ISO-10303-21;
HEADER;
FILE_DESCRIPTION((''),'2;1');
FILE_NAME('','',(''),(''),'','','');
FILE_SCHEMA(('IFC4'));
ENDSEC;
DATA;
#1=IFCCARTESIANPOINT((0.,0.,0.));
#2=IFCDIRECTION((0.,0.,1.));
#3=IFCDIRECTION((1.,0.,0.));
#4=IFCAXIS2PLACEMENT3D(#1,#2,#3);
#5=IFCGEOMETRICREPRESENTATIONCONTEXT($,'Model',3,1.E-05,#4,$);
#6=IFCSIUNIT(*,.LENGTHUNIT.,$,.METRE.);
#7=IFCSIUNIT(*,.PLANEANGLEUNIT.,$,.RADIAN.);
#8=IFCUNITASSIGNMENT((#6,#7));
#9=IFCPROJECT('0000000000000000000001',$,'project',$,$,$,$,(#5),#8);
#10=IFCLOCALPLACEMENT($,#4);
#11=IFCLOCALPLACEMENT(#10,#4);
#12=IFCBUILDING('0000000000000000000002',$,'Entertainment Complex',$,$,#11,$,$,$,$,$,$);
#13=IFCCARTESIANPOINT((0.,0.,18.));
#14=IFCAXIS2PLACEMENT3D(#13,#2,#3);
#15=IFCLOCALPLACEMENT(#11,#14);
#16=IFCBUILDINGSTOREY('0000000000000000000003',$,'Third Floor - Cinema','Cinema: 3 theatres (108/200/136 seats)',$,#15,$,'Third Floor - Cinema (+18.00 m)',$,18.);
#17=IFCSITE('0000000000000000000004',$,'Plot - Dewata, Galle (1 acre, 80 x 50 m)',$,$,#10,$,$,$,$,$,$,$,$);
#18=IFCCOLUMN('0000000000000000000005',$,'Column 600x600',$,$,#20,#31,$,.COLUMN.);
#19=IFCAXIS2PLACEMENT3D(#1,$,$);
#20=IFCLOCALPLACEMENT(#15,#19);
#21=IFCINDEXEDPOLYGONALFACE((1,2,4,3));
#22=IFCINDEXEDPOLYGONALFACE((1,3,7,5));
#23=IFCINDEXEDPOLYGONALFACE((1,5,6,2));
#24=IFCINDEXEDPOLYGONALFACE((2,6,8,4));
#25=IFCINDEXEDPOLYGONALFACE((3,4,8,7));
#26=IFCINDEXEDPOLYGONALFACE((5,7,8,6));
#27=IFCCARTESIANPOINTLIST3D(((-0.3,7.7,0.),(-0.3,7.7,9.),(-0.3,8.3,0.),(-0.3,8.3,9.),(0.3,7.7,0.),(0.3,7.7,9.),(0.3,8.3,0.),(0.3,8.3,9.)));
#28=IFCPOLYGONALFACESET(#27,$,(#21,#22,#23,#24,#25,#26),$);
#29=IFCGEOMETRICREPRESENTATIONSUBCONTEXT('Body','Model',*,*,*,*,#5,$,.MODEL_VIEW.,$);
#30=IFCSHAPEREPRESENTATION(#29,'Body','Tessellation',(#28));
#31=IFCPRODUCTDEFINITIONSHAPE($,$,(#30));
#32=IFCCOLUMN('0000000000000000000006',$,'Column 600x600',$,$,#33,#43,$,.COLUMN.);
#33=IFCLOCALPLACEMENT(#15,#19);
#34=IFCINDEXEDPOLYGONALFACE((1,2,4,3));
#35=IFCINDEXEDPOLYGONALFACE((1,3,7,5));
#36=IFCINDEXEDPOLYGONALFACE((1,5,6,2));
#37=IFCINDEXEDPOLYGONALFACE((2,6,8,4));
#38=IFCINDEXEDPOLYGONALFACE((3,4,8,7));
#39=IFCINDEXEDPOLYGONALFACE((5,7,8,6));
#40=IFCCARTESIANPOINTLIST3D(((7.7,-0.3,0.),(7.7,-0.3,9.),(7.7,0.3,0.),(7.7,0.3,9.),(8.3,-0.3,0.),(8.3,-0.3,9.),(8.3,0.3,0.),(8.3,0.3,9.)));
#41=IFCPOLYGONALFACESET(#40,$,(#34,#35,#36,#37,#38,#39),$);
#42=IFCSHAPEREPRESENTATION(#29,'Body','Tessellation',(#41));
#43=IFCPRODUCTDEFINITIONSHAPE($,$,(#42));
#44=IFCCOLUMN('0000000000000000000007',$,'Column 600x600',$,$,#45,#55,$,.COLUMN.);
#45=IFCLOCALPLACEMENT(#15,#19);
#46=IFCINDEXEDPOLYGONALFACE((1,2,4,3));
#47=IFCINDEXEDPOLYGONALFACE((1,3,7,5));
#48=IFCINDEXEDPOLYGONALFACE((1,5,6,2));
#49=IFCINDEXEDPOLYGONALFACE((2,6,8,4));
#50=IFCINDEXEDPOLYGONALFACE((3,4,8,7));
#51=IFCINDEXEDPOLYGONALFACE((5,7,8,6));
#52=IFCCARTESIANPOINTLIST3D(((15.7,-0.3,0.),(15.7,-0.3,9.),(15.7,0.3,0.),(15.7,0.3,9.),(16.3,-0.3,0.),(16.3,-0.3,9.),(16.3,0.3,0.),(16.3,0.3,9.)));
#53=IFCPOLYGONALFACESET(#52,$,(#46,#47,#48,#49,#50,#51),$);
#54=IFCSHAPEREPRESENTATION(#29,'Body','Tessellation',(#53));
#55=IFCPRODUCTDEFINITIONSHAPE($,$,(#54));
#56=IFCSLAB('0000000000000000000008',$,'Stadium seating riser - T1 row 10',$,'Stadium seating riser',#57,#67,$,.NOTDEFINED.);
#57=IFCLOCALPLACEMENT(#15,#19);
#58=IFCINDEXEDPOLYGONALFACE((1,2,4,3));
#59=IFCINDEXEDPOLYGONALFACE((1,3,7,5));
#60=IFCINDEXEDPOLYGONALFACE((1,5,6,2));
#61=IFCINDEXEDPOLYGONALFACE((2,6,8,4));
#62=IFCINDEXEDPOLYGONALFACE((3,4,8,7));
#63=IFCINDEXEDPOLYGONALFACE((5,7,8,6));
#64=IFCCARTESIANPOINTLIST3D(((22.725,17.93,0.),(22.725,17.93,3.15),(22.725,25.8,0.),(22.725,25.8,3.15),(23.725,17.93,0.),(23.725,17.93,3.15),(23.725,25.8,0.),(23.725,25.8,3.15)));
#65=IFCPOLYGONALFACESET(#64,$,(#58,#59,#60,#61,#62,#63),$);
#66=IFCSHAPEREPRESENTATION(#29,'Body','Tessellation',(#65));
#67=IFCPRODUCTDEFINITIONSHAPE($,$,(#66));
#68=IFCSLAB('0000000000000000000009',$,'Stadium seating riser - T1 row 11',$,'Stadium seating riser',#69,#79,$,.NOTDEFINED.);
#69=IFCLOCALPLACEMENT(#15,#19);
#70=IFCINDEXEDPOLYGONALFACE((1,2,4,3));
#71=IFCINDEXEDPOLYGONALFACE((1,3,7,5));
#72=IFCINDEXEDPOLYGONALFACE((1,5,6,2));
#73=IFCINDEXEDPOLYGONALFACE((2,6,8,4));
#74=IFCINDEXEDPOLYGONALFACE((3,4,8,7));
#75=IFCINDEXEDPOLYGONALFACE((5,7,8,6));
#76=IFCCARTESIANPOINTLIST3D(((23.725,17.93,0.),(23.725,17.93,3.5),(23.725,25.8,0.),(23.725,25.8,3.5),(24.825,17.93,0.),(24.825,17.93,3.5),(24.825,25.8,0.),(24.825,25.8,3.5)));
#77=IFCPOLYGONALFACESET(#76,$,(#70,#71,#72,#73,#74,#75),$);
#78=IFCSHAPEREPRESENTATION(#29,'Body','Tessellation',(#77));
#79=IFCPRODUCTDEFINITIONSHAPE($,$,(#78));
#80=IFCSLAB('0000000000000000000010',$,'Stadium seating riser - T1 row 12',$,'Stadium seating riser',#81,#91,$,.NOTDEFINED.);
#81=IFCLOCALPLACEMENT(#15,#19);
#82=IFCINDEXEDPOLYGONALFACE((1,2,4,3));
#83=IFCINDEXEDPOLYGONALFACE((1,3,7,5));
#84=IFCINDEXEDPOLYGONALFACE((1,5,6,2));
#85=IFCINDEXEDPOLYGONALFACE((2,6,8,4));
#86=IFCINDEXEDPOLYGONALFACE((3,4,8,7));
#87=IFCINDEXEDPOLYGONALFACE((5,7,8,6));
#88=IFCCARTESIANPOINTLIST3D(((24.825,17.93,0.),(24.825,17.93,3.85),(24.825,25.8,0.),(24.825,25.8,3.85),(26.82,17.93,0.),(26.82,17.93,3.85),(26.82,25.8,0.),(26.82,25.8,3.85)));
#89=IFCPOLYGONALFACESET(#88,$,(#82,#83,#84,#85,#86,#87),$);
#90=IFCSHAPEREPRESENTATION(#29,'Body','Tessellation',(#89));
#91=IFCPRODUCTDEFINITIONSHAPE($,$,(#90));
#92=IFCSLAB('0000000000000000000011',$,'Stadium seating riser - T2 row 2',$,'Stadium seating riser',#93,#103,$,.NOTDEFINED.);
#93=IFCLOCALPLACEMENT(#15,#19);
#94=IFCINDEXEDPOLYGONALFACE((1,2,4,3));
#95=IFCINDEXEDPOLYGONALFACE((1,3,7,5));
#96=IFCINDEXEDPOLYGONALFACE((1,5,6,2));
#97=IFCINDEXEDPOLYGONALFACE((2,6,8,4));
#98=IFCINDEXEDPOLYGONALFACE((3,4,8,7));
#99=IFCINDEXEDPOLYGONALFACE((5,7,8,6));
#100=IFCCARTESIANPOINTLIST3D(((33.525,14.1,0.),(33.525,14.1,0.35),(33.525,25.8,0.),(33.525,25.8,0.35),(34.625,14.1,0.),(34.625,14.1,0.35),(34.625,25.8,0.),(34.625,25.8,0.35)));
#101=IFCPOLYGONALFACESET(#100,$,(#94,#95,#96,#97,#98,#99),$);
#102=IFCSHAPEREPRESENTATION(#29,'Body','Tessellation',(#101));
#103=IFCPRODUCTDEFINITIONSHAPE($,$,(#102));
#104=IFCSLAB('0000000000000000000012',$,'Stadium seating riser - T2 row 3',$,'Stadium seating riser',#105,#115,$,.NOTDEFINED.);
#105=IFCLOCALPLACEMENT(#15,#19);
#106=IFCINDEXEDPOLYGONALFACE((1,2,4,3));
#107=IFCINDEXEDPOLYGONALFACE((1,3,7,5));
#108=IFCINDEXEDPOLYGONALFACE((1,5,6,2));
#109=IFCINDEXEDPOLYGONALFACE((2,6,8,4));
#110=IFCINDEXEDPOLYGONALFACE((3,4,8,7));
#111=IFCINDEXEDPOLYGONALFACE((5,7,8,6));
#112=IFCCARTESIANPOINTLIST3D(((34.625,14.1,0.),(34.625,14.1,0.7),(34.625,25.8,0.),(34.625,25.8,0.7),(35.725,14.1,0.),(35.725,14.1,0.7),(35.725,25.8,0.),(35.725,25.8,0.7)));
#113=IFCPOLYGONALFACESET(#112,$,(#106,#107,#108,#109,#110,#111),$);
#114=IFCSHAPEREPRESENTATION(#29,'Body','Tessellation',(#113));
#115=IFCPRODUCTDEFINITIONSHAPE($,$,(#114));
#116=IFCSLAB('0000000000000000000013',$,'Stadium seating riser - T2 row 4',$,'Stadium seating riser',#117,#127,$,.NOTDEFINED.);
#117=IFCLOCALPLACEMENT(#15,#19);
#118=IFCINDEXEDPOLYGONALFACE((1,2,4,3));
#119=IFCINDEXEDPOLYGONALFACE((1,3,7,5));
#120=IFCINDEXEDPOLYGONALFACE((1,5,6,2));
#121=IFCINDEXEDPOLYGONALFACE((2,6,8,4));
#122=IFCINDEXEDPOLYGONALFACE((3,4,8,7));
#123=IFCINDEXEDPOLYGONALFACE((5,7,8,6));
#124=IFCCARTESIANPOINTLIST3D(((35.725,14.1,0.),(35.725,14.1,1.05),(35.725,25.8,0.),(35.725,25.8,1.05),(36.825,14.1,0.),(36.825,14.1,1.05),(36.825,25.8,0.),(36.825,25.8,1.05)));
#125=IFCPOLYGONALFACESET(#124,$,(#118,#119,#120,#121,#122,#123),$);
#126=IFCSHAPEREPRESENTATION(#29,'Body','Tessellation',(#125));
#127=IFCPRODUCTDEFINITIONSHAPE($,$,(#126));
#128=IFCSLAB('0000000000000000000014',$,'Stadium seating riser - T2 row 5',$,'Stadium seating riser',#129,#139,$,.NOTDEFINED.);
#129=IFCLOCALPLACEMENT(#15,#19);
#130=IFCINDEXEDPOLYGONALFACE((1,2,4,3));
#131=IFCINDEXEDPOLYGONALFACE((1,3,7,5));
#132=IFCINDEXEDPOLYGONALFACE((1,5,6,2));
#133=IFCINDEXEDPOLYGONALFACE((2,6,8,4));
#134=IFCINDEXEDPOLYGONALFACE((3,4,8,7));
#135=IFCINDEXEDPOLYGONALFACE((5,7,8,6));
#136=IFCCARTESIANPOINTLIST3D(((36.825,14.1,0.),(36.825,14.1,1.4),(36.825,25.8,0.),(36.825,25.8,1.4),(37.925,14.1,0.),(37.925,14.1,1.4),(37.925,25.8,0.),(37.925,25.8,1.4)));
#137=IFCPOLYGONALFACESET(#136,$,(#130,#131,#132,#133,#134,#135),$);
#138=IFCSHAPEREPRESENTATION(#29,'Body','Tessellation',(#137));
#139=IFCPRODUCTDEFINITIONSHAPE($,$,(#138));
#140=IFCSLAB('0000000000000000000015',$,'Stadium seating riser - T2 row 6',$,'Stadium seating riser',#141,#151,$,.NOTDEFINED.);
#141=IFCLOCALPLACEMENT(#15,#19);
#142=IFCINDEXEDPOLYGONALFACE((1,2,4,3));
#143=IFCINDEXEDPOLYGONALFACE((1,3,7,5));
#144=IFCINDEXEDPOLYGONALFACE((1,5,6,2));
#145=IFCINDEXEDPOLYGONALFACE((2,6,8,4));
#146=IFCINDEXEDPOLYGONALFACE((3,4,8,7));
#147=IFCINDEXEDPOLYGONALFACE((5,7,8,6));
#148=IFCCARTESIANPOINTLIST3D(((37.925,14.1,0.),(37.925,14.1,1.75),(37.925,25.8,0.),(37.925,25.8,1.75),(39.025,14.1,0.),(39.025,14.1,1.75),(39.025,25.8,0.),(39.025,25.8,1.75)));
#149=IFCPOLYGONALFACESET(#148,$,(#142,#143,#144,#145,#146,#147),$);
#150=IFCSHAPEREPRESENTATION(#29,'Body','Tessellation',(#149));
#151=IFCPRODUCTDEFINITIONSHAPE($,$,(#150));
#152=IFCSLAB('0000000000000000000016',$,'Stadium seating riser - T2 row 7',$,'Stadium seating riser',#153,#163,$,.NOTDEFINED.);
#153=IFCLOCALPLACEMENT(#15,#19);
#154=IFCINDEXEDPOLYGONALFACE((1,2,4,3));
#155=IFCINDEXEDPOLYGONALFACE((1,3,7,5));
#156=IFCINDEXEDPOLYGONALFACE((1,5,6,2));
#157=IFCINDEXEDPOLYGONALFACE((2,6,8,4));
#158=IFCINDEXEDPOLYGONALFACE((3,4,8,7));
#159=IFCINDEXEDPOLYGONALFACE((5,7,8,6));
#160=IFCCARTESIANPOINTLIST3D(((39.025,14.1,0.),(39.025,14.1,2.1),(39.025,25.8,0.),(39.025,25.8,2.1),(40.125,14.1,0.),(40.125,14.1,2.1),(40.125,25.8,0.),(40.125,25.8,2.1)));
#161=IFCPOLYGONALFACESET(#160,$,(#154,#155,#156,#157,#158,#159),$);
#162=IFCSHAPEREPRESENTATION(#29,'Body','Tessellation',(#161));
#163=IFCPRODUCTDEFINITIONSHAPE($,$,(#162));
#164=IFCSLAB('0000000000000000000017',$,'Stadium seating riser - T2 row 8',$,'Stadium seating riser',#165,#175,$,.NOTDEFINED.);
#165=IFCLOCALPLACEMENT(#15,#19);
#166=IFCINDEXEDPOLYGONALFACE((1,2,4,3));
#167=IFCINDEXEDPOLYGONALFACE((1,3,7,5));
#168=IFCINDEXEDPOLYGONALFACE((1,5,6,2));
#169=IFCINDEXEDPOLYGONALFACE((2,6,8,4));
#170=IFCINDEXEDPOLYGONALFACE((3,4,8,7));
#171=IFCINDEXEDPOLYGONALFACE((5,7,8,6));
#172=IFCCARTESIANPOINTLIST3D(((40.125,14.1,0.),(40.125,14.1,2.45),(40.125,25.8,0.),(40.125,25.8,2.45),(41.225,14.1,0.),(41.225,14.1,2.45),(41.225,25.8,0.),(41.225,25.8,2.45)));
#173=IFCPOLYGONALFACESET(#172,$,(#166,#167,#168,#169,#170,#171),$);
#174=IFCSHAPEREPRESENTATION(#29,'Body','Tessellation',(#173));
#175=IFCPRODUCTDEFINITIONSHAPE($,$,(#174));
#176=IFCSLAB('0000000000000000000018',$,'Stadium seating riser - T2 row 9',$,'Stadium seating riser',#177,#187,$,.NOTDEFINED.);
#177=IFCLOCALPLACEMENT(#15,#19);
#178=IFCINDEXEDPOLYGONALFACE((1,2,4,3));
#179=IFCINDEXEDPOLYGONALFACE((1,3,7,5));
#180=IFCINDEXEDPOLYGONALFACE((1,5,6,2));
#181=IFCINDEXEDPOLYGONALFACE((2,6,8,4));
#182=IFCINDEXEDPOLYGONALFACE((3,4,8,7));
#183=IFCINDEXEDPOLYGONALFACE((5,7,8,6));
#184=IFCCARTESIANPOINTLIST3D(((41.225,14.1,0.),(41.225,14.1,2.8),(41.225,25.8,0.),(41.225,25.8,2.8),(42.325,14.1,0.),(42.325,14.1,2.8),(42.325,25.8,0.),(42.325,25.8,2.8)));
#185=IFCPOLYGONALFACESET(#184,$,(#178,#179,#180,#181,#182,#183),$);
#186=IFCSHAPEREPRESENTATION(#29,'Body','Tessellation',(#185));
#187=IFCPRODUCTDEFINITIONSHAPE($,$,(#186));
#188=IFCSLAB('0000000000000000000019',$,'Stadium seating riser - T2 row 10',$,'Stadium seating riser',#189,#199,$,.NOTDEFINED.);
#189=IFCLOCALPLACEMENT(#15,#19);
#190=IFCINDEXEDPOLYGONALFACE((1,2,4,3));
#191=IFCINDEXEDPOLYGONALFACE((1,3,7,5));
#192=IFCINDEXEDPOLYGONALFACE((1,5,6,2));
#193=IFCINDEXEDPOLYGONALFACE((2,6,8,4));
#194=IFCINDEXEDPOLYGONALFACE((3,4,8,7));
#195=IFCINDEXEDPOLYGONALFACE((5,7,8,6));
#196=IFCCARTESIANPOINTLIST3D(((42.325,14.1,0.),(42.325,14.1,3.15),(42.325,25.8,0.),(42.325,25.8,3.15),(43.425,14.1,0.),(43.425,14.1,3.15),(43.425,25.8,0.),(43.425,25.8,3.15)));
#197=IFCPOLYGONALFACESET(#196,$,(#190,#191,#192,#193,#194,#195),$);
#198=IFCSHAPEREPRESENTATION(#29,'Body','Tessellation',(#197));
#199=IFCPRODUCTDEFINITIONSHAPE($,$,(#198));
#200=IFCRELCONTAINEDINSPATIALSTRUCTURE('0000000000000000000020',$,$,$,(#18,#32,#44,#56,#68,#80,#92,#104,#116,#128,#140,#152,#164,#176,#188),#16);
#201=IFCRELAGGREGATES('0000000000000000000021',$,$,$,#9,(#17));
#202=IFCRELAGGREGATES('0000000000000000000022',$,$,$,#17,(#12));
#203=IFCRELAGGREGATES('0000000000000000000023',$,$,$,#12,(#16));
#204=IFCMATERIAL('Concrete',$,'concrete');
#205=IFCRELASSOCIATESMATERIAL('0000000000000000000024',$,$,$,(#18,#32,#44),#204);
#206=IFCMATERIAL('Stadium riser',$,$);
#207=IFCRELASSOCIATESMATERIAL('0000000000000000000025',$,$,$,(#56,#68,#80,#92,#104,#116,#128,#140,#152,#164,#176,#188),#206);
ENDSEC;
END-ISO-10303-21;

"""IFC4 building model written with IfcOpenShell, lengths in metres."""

from ifc_helpers import new_model, si_unit, frame, origin_with_axes, place, context, subcontext, project, spatial, polyline, outline, extrude, material, element, save


model = new_model("IFC4")

# Units and contexts
model_context = context("Model", 3, precision=1e-05, world=origin_with_axes())
body_context = subcontext(model_context, "Body", "Model", "MODEL_VIEW")
ifc_project = project(units=[si_unit("LENGTHUNIT", "METRE"), si_unit("PLANEANGLEUNIT", "RADIAN")], contexts=[model_context])

# Site, building, storey
site_placement = place(None, origin_with_axes())
site = spatial("IfcSite", under=ifc_project, at=site_placement, Name="Plot - Dewata, Galle (1 acre, 80 x 50 m)")
building_placement = place(site_placement, origin_with_axes())
building = spatial("IfcBuilding", under=site, at=building_placement, Name="Entertainment Complex")
storey_placement = place(building_placement, frame((0.0, 0.0, 18.0), z_axis=(0.0, 0.0, 1.0), x_axis=(1.0, 0.0, 0.0)))
storey = spatial("IfcBuildingStorey", under=building, at=storey_placement, Name="Third Floor - Cinema", Description="Cinema: 3 theatres (108/200/136 seats)", LongName="Third Floor - Cinema (+18.00 m)", Elevation=18.0)

# Columns
ifc_material_1 = material(Name="Concrete", Category="concrete")
for number, where, z_axis, x_axis, name in (
    (1, (0.0, 8.0, 0.0), (0.0, 0.0, 1.0), (1.0, 0.0, 0.0), "Column 600x600"),
    (2, (8.0, 0.0, 0.0), (0.0, 0.0, 1.0), (1.0, 0.0, 0.0), "Column 600x600"),
    (3, (16.0, 0.0, 0.0), (0.0, 0.0, 1.0), (1.0, 0.0, 0.0), "Column 600x600"),
):
    element("IfcColumn", number, at=place(storey_placement, frame(where, z_axis=z_axis, x_axis=x_axis)), inside=storey, material=ifc_material_1, Name=name, PredefinedType="COLUMN", context=body_context, shape_type="SweptSolid", body=[
        extrude(outline(polyline([(-0.3, -0.3), (0.3, -0.3), (0.3, 0.3), (-0.3, 0.3), (-0.3, -0.3)])), origin_with_axes(), (0.0, 0.0, 1.0), 9.0),
    ])

# Slabs
ifc_material_2 = material(Name="Stadium riser")
slab_1_placement = place(storey_placement, origin_with_axes())
element("IfcSlab", 4, at=slab_1_placement, inside=storey, material=ifc_material_2, Name="Stadium seating riser - T1 row 10", ObjectType="Stadium seating riser", PredefinedType="NOTDEFINED", context=body_context, shape_type="SweptSolid", body=[
    extrude(outline(polyline([(22.725, 25.8), (22.725, 17.93), (23.725, 17.93), (23.725, 25.8), (22.725, 25.8)])), origin_with_axes(), (0.0, 0.0, 1.0), 3.15),
])
slab_2_placement = place(storey_placement, origin_with_axes())
element("IfcSlab", 5, at=slab_2_placement, inside=storey, material=ifc_material_2, Name="Stadium seating riser - T1 row 11", ObjectType="Stadium seating riser", PredefinedType="NOTDEFINED", context=body_context, shape_type="SweptSolid", body=[
    extrude(outline(polyline([(23.725, 25.8), (23.725, 17.93), (24.825, 17.93), (24.825, 25.8), (23.725, 25.8)])), origin_with_axes(), (0.0, 0.0, 1.0), 3.5),
])
slab_3_placement = place(storey_placement, origin_with_axes())
element("IfcSlab", 6, at=slab_3_placement, inside=storey, material=ifc_material_2, Name="Stadium seating riser - T1 row 12", ObjectType="Stadium seating riser", PredefinedType="NOTDEFINED", context=body_context, shape_type="SweptSolid", body=[
    extrude(outline(polyline([(24.825, 25.8), (24.825, 17.93), (26.82, 17.93), (26.82, 25.8), (24.825, 25.8)])), origin_with_axes(), (0.0, 0.0, 1.0), 3.85),
])
slab_4_placement = place(storey_placement, origin_with_axes())
element("IfcSlab", 7, at=slab_4_placement, inside=storey, material=ifc_material_2, Name="Stadium seating riser - T2 row 2", ObjectType="Stadium seating riser", PredefinedType="NOTDEFINED", context=body_context, shape_type="SweptSolid", body=[
    extrude(outline(polyline([(33.525, 25.8), (33.525, 14.1), (34.625, 14.1), (34.625, 25.8), (33.525, 25.8)])), origin_with_axes(), (0.0, 0.0, 1.0), 0.35),
])
slab_5_placement = place(storey_placement, origin_with_axes())
element("IfcSlab", 8, at=slab_5_placement, inside=storey, material=ifc_material_2, Name="Stadium seating riser - T2 row 3", ObjectType="Stadium seating riser", PredefinedType="NOTDEFINED", context=body_context, shape_type="SweptSolid", body=[
    extrude(outline(polyline([(34.625, 25.8), (34.625, 14.1), (35.725, 14.1), (35.725, 25.8), (34.625, 25.8)])), origin_with_axes(), (0.0, 0.0, 1.0), 0.7),
])
slab_6_placement = place(storey_placement, origin_with_axes())
element("IfcSlab", 9, at=slab_6_placement, inside=storey, material=ifc_material_2, Name="Stadium seating riser - T2 row 4", ObjectType="Stadium seating riser", PredefinedType="NOTDEFINED", context=body_context, shape_type="SweptSolid", body=[
    extrude(outline(polyline([(35.725, 25.8), (35.725, 14.1), (36.825, 14.1), (36.825, 25.8), (35.725, 25.8)])), origin_with_axes(), (0.0, 0.0, 1.0), 1.05),
])
slab_7_placement = place(storey_placement, origin_with_axes())
element("IfcSlab", 10, at=slab_7_placement, inside=storey, material=ifc_material_2, Name="Stadium seating riser - T2 row 5", ObjectType="Stadium seating riser", PredefinedType="NOTDEFINED", context=body_context, shape_type="SweptSolid", body=[
    extrude(outline(polyline([(36.825, 25.8), (36.825, 14.1), (37.925, 14.1), (37.925, 25.8), (36.825, 25.8)])), origin_with_axes(), (0.0, 0.0, 1.0), 1.4),
])
slab_8_placement = place(storey_placement, origin_with_axes())
element("IfcSlab", 11, at=slab_8_placement, inside=storey, material=ifc_material_2, Name="Stadium seating riser - T2 row 6", ObjectType="Stadium seating riser", PredefinedType="NOTDEFINED", context=body_context, shape_type="SweptSolid", body=[
    extrude(outline(polyline([(37.925, 25.8), (37.925, 14.1), (39.025, 14.1), (39.025, 25.8), (37.925, 25.8)])), origin_with_axes(), (0.0, 0.0, 1.0), 1.75),
])
slab_9_placement = place(storey_placement, origin_with_axes())
element("IfcSlab", 12, at=slab_9_placement, inside=storey, material=ifc_material_2, Name="Stadium seating riser - T2 row 7", ObjectType="Stadium seating riser", PredefinedType="NOTDEFINED", context=body_context, shape_type="SweptSolid", body=[
    extrude(outline(polyline([(39.025, 25.8), (39.025, 14.1), (40.125, 14.1), (40.125, 25.8), (39.025, 25.8)])), origin_with_axes(), (0.0, 0.0, 1.0), 2.1),
])
slab_10_placement = place(storey_placement, origin_with_axes())
element("IfcSlab", 13, at=slab_10_placement, inside=storey, material=ifc_material_2, Name="Stadium seating riser - T2 row 8", ObjectType="Stadium seating riser", PredefinedType="NOTDEFINED", context=body_context, shape_type="SweptSolid", body=[
    extrude(outline(polyline([(40.125, 25.8), (40.125, 14.1), (41.225, 14.1), (41.225, 25.8), (40.125, 25.8)])), origin_with_axes(), (0.0, 0.0, 1.0), 2.45),
])
slab_11_placement = place(storey_placement, origin_with_axes())
element("IfcSlab", 14, at=slab_11_placement, inside=storey, material=ifc_material_2, Name="Stadium seating riser - T2 row 9", ObjectType="Stadium seating riser", PredefinedType="NOTDEFINED", context=body_context, shape_type="SweptSolid", body=[
    extrude(outline(polyline([(41.225, 25.8), (41.225, 14.1), (42.325, 14.1), (42.325, 25.8), (41.225, 25.8)])), origin_with_axes(), (0.0, 0.0, 1.0), 2.8),
])
slab_12_placement = place(storey_placement, origin_with_axes())
element("IfcSlab", 15, at=slab_12_placement, inside=storey, material=ifc_material_2, Name="Stadium seating riser - T2 row 10", ObjectType="Stadium seating riser", PredefinedType="NOTDEFINED", context=body_context, shape_type="SweptSolid", body=[
    extrude(outline(polyline([(42.325, 25.8), (42.325, 14.1), (43.425, 14.1), (43.425, 25.8), (42.325, 25.8)])), origin_with_axes(), (0.0, 0.0, 1.0), 3.15),
])

save(model, "model.ifc")
